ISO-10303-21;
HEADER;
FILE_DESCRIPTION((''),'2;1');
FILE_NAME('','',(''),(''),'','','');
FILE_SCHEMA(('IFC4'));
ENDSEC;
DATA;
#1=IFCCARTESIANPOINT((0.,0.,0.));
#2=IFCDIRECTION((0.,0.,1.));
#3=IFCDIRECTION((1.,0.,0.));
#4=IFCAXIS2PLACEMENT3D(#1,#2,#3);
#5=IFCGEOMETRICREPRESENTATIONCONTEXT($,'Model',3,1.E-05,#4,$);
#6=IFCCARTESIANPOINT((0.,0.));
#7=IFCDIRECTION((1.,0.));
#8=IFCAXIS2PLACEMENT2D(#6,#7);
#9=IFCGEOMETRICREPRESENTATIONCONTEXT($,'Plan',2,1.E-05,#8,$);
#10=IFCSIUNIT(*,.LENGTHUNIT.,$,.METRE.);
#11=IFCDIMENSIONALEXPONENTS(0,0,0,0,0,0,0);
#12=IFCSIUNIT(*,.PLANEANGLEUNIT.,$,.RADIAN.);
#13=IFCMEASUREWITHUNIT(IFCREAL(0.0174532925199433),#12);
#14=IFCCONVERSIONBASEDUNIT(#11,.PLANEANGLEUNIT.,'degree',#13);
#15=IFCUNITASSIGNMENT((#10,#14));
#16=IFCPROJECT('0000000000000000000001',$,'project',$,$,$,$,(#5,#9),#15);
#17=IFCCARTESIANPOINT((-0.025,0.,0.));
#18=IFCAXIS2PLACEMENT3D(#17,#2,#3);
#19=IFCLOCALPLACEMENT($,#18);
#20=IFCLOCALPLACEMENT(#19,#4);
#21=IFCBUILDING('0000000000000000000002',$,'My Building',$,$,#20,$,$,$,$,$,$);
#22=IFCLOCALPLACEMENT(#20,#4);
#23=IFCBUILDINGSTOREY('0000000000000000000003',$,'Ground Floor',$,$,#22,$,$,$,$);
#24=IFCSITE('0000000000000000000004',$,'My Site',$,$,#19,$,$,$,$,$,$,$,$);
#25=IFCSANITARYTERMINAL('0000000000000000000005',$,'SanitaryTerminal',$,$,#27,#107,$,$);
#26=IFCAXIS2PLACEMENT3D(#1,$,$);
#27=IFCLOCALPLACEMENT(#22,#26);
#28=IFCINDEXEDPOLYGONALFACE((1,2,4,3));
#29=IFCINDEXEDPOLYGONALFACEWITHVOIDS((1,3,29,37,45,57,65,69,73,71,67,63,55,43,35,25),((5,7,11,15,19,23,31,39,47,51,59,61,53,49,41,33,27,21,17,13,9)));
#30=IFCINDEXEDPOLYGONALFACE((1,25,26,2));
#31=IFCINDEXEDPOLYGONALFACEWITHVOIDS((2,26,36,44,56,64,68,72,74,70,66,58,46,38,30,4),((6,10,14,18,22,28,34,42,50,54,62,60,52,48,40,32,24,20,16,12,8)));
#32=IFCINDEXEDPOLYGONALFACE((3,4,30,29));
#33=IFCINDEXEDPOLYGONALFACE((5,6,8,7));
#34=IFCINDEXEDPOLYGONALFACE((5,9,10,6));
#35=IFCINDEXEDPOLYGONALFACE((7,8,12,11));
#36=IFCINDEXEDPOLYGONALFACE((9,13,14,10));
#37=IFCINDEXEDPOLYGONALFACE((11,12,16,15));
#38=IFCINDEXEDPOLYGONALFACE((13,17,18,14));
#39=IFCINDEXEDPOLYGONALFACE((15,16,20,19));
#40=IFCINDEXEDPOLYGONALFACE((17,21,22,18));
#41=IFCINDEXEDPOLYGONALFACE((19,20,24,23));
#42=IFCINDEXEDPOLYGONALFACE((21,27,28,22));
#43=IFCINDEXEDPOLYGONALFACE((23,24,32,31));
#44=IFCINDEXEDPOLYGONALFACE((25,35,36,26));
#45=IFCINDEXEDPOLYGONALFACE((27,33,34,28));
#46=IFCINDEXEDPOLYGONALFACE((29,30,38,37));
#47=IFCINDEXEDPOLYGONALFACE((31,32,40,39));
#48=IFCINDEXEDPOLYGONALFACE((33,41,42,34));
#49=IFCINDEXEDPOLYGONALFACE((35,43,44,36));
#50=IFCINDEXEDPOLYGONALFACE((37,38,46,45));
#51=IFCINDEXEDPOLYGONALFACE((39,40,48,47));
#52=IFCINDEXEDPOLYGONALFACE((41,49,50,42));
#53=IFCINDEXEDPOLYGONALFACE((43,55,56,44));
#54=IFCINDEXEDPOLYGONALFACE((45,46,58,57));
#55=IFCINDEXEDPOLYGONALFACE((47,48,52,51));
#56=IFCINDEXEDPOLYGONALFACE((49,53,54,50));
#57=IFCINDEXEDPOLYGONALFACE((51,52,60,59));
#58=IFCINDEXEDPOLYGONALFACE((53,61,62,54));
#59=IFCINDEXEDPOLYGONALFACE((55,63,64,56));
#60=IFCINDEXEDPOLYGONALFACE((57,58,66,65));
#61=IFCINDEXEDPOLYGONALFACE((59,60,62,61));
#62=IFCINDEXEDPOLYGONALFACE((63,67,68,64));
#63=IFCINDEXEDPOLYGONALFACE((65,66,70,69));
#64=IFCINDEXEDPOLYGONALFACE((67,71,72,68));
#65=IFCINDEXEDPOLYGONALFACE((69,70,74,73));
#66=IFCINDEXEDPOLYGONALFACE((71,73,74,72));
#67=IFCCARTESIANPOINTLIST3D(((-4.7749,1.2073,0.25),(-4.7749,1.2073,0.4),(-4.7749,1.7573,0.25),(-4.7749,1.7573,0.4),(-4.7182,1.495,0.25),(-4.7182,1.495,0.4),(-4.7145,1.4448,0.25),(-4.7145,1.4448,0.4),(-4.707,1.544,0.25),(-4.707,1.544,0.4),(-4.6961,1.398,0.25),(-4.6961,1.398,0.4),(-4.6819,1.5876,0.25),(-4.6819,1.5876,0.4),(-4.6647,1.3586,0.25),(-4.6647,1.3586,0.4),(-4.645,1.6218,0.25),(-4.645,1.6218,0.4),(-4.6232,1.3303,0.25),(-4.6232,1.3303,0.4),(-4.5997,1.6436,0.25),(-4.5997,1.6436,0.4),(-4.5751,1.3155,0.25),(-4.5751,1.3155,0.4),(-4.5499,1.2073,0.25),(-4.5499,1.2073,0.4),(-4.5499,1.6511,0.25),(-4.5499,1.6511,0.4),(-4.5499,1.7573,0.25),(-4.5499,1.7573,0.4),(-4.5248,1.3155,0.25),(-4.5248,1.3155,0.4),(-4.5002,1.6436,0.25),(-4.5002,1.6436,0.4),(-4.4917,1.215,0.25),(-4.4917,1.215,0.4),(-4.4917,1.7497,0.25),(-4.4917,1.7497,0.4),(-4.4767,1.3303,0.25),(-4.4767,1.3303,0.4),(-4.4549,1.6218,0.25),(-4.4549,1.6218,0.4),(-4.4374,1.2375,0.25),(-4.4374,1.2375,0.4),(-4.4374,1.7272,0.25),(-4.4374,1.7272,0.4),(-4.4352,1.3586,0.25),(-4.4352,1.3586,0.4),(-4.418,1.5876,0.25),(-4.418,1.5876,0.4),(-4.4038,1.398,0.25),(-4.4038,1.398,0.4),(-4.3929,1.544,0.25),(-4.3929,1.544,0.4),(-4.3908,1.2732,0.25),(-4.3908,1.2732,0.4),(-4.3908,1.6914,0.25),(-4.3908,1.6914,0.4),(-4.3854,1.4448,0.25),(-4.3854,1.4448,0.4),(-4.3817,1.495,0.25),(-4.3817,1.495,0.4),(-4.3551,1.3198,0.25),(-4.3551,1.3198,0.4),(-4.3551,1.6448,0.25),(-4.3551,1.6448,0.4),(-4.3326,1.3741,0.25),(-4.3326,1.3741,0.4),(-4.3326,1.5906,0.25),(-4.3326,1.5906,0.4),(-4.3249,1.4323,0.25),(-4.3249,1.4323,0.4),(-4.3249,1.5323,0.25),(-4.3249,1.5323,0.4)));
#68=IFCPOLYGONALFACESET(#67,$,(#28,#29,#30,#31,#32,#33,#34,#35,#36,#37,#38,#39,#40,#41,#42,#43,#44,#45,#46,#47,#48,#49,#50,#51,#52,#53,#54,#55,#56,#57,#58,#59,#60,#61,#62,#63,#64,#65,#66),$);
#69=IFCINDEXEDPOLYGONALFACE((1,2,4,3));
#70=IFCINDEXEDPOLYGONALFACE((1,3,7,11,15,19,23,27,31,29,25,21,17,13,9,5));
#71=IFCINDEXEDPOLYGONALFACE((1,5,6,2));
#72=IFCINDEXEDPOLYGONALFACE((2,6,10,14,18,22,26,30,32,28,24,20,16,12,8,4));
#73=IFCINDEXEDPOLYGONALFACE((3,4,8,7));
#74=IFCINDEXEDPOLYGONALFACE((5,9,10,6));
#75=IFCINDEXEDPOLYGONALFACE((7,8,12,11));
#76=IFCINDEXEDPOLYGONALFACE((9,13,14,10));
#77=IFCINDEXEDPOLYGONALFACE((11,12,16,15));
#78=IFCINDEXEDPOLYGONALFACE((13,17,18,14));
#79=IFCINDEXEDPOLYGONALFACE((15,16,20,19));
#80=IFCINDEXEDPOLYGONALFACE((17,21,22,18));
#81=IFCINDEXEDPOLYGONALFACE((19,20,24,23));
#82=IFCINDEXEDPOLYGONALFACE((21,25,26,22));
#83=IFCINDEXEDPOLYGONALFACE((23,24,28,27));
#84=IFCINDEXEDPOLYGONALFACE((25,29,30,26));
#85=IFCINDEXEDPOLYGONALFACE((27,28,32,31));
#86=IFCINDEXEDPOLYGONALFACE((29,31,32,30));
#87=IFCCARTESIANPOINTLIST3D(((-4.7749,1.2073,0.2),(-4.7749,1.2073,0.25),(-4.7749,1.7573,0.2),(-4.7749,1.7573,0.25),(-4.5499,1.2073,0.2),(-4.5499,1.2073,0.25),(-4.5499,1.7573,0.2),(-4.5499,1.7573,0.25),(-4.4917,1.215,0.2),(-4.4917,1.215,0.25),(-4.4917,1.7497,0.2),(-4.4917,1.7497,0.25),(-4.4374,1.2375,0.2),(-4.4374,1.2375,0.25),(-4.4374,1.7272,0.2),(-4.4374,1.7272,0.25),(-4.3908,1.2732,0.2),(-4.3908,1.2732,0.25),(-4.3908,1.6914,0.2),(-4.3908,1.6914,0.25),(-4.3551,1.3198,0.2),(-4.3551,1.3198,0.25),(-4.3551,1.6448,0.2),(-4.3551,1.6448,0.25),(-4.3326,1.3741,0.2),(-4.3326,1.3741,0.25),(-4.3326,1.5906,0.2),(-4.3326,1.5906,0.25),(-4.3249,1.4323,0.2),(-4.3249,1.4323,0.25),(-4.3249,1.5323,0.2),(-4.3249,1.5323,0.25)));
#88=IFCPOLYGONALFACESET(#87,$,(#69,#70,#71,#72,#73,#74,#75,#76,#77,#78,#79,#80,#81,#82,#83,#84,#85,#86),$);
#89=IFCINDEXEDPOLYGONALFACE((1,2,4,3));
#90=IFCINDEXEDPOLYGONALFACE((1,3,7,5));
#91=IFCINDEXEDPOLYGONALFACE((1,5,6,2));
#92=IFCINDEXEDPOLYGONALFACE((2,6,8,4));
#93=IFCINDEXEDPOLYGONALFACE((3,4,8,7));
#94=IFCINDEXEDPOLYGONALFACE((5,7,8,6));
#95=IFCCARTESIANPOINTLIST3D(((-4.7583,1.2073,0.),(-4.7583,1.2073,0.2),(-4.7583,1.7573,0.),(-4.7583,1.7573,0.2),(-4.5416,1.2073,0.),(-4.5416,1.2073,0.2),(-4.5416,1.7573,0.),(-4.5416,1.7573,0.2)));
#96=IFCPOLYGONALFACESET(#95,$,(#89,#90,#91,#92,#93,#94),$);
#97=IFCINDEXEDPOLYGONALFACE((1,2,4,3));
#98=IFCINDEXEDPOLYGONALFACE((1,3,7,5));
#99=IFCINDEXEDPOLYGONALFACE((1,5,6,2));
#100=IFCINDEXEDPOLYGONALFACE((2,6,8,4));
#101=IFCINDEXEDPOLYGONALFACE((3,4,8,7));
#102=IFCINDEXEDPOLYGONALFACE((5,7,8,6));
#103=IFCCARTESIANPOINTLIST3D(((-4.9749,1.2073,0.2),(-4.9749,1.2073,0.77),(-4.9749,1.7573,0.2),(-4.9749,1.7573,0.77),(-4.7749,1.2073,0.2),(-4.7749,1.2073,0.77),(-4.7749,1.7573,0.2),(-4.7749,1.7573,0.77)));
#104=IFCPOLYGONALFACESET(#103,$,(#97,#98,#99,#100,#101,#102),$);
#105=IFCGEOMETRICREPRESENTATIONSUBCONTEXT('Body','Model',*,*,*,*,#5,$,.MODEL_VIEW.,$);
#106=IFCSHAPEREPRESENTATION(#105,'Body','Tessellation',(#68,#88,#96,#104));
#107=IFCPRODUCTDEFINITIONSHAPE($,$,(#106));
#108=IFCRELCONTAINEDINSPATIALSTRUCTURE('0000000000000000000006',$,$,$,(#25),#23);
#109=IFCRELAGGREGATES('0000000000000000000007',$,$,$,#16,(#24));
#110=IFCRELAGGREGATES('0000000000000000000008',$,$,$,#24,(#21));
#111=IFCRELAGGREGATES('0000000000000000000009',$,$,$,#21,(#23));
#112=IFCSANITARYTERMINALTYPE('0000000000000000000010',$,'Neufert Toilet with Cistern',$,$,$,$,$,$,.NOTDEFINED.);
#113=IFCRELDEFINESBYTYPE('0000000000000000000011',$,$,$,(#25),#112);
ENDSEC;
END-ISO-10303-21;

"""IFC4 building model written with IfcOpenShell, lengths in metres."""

from ifc_helpers import new_model, entity, si_unit, converted_unit, frame, frame_2d, origin_with_axes, origin_2d_with_axis, place, context, subcontext, project, spatial, line, arc, indexed_curve, circle_curve, outline, extrude, shape, source, transform, mapped, type_object, type_shapes, element, save


model = new_model("IFC4")

# Units and contexts
model_context = context("Model", 3, precision=1e-05, world=origin_with_axes())
plan_context = context("Plan", 2, precision=1e-05, world=origin_2d_with_axis())
body_context_1 = subcontext(model_context, "Body", "Model", "MODEL_VIEW")
body_context_2 = subcontext(plan_context, "Body", "Plan", "PLAN_VIEW")
ifc_project = project(units=[si_unit("LENGTHUNIT", "METRE"), converted_unit("PLANEANGLEUNIT", "degree", entity("IfcReal", 0.0174532925199433), si_unit("PLANEANGLEUNIT", "RADIAN"), dimensions=[0, 0, 0, 0, 0, 0, 0])], contexts=[model_context, plan_context])

# Site, building, storey
site_placement = place(None, frame((-0.025, 0.0, 0.0), z_axis=(0.0, 0.0, 1.0), x_axis=(1.0, 0.0, 0.0)))
site = spatial("IfcSite", under=ifc_project, at=site_placement, Name="My Site")
building_placement = place(site_placement, origin_with_axes())
building = spatial("IfcBuilding", under=site, at=building_placement, Name="My Building")
storey_placement = place(building_placement, frame((0.0, 0.0, 0.0), z_axis=(0.0, 0.0, 1.0), x_axis=(1.0, 0.0, 0.0)))
storey = spatial("IfcBuildingStorey", under=building, at=storey_placement, Name="Ground Floor")

# Sanitary terminal
sanitary_terminal_type_1 = type_object("IfcSanitaryTerminalType", Name="Neufert Toilet with Cistern", PredefinedType="NOTDEFINED")
shared_shape_1 = source(origin_with_axes(), body_context_1, "Body", "SweptSolid", [
    extrude(outline(indexed_curve([(-0.275, -0.2), (0.275, -0.2), (0.275, -0.425), (0.2091, -0.5841), (0.05, -0.65), (-0.05, -0.65), (-0.2091, -0.5841), (-0.275, -0.425)], segments=[line(1, 2), line(2, 3), arc(3, 4, 5), line(5, 6), arc(6, 7, 8), line(8, 1)]), holes=[circle_curve(frame_2d((0.0, -0.425)), 0.1688)]), frame((0.0, 0.0, 0.25), z_axis=(0.0, 0.0, 1.0), x_axis=(1.0, 0.0, 0.0)), (0.0, 0.0, 1.0), 0.15),
    extrude(outline(indexed_curve([(-0.275, -0.2), (0.275, -0.2), (0.275, -0.425), (0.2091, -0.5841), (0.05, -0.65), (-0.05, -0.65), (-0.2091, -0.5841), (-0.275, -0.425)], segments=[line(1, 2), line(2, 3), arc(3, 4, 5), line(5, 6), arc(6, 7, 8), line(8, 1)])), frame((0.0, 0.0, 0.2), z_axis=(0.0, 0.0, 1.0), x_axis=(1.0, 0.0, 0.0)), (0.0, 0.0, 1.0), 0.05),
    extrude(outline(indexed_curve([(-0.275, -0.2167), (0.275, -0.2167), (0.275, -0.4333), (-0.275, -0.4333)], segments=[line(1, 2, 3, 4, 1)])), origin_with_axes(), (0.0, 0.0, 1.0), 0.2),
    extrude(outline(indexed_curve([(-0.275, 0.0), (0.275, 0.0), (0.275, -0.2), (-0.275, -0.2)], segments=[line(1, 2, 3, 4, 1)])), frame((0.0, 0.0, 0.2), z_axis=(0.0, 0.0, 1.0), x_axis=(1.0, 0.0, 0.0)), (0.0, 0.0, 1.0), 0.57),
])
shared_shape_2 = source(origin_with_axes(), body_context_2, "Body", "Curve2D", [
    entity("IfcIndexedPolyCurve", entity("IfcCartesianPointList2D", [[-0.275, 0.0], [0.275, 0.0], [0.275, -0.2], [-0.275, -0.2]]), [entity("IfcLineIndex", [1, 2, 3, 4, 1])]),
    entity("IfcIndexedPolyCurve", entity("IfcCartesianPointList2D", [[0.165, -0.2], [0.1925, -0.335]])),
    entity("IfcTrimmedCurve", entity("IfcEllipse", entity("IfcAxis2Placement2D", entity("IfcCartesianPoint", [0.0, -0.335]), entity("IfcDirection", [1.0, 0.0])), 0.1925, 0.315), [entity("IfcCartesianPoint", [-0.1925, -0.335])], [entity("IfcCartesianPoint", [0.1925, -0.335])], True, "CARTESIAN"),
    entity("IfcIndexedPolyCurve", entity("IfcCartesianPointList2D", [[-0.165, -0.2], [-0.1925, -0.335]])),
    entity("IfcEllipse", entity("IfcAxis2Placement2D", entity("IfcCartesianPoint", [0.0, -0.452]), entity("IfcDirection", [1.0, 0.0])), 0.1313, 0.1575),
    entity("IfcIndexedPolyCurve", entity("IfcCartesianPointList2D", [[-0.0344, -0.452], [-0.0344, -0.4295], [0.0344, -0.4295], [0.0344, -0.452]])),
    entity("IfcTrimmedCurve", entity("IfcEllipse", entity("IfcAxis2Placement2D", entity("IfcCartesianPoint", [0.0, -0.452]), entity("IfcDirection", [1.0, 0.0])), 0.0344, 0.0225), [entity("IfcCartesianPoint", [-0.0344, -0.452])], [entity("IfcCartesianPoint", [0.0344, -0.452])], True, "CARTESIAN"),
])
type_shapes(sanitary_terminal_type_1, [shared_shape_1, shared_shape_2])
sanitary_terminal_1_placement = place(storey_placement, frame((-4.9749, 1.4823, 0.0), z_axis=(0.0, 0.0, 1.0), x_axis=(0.0, 1.0, 0.0)))
element("IfcSanitaryTerminal", 1, at=sanitary_terminal_1_placement, inside=storey, type_object=sanitary_terminal_type_1, Name="SanitaryTerminal", shapes=[
    shape(body_context_1, "Body", "MappedRepresentation", [mapped(shared_shape_1, transform((0.0, 0.0, 0.0), x_axis=(1.0, 0.0, 0.0), y_axis=(0.0, 1.0, 0.0), z_axis=(0.0, 0.0, 1.0), scale=1.0))]),
    shape(body_context_2, "Body", "MappedRepresentation", [mapped(shared_shape_2, transform((0.0, 0.0, 0.0), x_axis=(1.0, 0.0, 0.0), y_axis=(0.0, 1.0, 0.0), z_axis=(0.0, 0.0, 1.0), scale=1.0))]),
])

save(model, "model.ifc")
